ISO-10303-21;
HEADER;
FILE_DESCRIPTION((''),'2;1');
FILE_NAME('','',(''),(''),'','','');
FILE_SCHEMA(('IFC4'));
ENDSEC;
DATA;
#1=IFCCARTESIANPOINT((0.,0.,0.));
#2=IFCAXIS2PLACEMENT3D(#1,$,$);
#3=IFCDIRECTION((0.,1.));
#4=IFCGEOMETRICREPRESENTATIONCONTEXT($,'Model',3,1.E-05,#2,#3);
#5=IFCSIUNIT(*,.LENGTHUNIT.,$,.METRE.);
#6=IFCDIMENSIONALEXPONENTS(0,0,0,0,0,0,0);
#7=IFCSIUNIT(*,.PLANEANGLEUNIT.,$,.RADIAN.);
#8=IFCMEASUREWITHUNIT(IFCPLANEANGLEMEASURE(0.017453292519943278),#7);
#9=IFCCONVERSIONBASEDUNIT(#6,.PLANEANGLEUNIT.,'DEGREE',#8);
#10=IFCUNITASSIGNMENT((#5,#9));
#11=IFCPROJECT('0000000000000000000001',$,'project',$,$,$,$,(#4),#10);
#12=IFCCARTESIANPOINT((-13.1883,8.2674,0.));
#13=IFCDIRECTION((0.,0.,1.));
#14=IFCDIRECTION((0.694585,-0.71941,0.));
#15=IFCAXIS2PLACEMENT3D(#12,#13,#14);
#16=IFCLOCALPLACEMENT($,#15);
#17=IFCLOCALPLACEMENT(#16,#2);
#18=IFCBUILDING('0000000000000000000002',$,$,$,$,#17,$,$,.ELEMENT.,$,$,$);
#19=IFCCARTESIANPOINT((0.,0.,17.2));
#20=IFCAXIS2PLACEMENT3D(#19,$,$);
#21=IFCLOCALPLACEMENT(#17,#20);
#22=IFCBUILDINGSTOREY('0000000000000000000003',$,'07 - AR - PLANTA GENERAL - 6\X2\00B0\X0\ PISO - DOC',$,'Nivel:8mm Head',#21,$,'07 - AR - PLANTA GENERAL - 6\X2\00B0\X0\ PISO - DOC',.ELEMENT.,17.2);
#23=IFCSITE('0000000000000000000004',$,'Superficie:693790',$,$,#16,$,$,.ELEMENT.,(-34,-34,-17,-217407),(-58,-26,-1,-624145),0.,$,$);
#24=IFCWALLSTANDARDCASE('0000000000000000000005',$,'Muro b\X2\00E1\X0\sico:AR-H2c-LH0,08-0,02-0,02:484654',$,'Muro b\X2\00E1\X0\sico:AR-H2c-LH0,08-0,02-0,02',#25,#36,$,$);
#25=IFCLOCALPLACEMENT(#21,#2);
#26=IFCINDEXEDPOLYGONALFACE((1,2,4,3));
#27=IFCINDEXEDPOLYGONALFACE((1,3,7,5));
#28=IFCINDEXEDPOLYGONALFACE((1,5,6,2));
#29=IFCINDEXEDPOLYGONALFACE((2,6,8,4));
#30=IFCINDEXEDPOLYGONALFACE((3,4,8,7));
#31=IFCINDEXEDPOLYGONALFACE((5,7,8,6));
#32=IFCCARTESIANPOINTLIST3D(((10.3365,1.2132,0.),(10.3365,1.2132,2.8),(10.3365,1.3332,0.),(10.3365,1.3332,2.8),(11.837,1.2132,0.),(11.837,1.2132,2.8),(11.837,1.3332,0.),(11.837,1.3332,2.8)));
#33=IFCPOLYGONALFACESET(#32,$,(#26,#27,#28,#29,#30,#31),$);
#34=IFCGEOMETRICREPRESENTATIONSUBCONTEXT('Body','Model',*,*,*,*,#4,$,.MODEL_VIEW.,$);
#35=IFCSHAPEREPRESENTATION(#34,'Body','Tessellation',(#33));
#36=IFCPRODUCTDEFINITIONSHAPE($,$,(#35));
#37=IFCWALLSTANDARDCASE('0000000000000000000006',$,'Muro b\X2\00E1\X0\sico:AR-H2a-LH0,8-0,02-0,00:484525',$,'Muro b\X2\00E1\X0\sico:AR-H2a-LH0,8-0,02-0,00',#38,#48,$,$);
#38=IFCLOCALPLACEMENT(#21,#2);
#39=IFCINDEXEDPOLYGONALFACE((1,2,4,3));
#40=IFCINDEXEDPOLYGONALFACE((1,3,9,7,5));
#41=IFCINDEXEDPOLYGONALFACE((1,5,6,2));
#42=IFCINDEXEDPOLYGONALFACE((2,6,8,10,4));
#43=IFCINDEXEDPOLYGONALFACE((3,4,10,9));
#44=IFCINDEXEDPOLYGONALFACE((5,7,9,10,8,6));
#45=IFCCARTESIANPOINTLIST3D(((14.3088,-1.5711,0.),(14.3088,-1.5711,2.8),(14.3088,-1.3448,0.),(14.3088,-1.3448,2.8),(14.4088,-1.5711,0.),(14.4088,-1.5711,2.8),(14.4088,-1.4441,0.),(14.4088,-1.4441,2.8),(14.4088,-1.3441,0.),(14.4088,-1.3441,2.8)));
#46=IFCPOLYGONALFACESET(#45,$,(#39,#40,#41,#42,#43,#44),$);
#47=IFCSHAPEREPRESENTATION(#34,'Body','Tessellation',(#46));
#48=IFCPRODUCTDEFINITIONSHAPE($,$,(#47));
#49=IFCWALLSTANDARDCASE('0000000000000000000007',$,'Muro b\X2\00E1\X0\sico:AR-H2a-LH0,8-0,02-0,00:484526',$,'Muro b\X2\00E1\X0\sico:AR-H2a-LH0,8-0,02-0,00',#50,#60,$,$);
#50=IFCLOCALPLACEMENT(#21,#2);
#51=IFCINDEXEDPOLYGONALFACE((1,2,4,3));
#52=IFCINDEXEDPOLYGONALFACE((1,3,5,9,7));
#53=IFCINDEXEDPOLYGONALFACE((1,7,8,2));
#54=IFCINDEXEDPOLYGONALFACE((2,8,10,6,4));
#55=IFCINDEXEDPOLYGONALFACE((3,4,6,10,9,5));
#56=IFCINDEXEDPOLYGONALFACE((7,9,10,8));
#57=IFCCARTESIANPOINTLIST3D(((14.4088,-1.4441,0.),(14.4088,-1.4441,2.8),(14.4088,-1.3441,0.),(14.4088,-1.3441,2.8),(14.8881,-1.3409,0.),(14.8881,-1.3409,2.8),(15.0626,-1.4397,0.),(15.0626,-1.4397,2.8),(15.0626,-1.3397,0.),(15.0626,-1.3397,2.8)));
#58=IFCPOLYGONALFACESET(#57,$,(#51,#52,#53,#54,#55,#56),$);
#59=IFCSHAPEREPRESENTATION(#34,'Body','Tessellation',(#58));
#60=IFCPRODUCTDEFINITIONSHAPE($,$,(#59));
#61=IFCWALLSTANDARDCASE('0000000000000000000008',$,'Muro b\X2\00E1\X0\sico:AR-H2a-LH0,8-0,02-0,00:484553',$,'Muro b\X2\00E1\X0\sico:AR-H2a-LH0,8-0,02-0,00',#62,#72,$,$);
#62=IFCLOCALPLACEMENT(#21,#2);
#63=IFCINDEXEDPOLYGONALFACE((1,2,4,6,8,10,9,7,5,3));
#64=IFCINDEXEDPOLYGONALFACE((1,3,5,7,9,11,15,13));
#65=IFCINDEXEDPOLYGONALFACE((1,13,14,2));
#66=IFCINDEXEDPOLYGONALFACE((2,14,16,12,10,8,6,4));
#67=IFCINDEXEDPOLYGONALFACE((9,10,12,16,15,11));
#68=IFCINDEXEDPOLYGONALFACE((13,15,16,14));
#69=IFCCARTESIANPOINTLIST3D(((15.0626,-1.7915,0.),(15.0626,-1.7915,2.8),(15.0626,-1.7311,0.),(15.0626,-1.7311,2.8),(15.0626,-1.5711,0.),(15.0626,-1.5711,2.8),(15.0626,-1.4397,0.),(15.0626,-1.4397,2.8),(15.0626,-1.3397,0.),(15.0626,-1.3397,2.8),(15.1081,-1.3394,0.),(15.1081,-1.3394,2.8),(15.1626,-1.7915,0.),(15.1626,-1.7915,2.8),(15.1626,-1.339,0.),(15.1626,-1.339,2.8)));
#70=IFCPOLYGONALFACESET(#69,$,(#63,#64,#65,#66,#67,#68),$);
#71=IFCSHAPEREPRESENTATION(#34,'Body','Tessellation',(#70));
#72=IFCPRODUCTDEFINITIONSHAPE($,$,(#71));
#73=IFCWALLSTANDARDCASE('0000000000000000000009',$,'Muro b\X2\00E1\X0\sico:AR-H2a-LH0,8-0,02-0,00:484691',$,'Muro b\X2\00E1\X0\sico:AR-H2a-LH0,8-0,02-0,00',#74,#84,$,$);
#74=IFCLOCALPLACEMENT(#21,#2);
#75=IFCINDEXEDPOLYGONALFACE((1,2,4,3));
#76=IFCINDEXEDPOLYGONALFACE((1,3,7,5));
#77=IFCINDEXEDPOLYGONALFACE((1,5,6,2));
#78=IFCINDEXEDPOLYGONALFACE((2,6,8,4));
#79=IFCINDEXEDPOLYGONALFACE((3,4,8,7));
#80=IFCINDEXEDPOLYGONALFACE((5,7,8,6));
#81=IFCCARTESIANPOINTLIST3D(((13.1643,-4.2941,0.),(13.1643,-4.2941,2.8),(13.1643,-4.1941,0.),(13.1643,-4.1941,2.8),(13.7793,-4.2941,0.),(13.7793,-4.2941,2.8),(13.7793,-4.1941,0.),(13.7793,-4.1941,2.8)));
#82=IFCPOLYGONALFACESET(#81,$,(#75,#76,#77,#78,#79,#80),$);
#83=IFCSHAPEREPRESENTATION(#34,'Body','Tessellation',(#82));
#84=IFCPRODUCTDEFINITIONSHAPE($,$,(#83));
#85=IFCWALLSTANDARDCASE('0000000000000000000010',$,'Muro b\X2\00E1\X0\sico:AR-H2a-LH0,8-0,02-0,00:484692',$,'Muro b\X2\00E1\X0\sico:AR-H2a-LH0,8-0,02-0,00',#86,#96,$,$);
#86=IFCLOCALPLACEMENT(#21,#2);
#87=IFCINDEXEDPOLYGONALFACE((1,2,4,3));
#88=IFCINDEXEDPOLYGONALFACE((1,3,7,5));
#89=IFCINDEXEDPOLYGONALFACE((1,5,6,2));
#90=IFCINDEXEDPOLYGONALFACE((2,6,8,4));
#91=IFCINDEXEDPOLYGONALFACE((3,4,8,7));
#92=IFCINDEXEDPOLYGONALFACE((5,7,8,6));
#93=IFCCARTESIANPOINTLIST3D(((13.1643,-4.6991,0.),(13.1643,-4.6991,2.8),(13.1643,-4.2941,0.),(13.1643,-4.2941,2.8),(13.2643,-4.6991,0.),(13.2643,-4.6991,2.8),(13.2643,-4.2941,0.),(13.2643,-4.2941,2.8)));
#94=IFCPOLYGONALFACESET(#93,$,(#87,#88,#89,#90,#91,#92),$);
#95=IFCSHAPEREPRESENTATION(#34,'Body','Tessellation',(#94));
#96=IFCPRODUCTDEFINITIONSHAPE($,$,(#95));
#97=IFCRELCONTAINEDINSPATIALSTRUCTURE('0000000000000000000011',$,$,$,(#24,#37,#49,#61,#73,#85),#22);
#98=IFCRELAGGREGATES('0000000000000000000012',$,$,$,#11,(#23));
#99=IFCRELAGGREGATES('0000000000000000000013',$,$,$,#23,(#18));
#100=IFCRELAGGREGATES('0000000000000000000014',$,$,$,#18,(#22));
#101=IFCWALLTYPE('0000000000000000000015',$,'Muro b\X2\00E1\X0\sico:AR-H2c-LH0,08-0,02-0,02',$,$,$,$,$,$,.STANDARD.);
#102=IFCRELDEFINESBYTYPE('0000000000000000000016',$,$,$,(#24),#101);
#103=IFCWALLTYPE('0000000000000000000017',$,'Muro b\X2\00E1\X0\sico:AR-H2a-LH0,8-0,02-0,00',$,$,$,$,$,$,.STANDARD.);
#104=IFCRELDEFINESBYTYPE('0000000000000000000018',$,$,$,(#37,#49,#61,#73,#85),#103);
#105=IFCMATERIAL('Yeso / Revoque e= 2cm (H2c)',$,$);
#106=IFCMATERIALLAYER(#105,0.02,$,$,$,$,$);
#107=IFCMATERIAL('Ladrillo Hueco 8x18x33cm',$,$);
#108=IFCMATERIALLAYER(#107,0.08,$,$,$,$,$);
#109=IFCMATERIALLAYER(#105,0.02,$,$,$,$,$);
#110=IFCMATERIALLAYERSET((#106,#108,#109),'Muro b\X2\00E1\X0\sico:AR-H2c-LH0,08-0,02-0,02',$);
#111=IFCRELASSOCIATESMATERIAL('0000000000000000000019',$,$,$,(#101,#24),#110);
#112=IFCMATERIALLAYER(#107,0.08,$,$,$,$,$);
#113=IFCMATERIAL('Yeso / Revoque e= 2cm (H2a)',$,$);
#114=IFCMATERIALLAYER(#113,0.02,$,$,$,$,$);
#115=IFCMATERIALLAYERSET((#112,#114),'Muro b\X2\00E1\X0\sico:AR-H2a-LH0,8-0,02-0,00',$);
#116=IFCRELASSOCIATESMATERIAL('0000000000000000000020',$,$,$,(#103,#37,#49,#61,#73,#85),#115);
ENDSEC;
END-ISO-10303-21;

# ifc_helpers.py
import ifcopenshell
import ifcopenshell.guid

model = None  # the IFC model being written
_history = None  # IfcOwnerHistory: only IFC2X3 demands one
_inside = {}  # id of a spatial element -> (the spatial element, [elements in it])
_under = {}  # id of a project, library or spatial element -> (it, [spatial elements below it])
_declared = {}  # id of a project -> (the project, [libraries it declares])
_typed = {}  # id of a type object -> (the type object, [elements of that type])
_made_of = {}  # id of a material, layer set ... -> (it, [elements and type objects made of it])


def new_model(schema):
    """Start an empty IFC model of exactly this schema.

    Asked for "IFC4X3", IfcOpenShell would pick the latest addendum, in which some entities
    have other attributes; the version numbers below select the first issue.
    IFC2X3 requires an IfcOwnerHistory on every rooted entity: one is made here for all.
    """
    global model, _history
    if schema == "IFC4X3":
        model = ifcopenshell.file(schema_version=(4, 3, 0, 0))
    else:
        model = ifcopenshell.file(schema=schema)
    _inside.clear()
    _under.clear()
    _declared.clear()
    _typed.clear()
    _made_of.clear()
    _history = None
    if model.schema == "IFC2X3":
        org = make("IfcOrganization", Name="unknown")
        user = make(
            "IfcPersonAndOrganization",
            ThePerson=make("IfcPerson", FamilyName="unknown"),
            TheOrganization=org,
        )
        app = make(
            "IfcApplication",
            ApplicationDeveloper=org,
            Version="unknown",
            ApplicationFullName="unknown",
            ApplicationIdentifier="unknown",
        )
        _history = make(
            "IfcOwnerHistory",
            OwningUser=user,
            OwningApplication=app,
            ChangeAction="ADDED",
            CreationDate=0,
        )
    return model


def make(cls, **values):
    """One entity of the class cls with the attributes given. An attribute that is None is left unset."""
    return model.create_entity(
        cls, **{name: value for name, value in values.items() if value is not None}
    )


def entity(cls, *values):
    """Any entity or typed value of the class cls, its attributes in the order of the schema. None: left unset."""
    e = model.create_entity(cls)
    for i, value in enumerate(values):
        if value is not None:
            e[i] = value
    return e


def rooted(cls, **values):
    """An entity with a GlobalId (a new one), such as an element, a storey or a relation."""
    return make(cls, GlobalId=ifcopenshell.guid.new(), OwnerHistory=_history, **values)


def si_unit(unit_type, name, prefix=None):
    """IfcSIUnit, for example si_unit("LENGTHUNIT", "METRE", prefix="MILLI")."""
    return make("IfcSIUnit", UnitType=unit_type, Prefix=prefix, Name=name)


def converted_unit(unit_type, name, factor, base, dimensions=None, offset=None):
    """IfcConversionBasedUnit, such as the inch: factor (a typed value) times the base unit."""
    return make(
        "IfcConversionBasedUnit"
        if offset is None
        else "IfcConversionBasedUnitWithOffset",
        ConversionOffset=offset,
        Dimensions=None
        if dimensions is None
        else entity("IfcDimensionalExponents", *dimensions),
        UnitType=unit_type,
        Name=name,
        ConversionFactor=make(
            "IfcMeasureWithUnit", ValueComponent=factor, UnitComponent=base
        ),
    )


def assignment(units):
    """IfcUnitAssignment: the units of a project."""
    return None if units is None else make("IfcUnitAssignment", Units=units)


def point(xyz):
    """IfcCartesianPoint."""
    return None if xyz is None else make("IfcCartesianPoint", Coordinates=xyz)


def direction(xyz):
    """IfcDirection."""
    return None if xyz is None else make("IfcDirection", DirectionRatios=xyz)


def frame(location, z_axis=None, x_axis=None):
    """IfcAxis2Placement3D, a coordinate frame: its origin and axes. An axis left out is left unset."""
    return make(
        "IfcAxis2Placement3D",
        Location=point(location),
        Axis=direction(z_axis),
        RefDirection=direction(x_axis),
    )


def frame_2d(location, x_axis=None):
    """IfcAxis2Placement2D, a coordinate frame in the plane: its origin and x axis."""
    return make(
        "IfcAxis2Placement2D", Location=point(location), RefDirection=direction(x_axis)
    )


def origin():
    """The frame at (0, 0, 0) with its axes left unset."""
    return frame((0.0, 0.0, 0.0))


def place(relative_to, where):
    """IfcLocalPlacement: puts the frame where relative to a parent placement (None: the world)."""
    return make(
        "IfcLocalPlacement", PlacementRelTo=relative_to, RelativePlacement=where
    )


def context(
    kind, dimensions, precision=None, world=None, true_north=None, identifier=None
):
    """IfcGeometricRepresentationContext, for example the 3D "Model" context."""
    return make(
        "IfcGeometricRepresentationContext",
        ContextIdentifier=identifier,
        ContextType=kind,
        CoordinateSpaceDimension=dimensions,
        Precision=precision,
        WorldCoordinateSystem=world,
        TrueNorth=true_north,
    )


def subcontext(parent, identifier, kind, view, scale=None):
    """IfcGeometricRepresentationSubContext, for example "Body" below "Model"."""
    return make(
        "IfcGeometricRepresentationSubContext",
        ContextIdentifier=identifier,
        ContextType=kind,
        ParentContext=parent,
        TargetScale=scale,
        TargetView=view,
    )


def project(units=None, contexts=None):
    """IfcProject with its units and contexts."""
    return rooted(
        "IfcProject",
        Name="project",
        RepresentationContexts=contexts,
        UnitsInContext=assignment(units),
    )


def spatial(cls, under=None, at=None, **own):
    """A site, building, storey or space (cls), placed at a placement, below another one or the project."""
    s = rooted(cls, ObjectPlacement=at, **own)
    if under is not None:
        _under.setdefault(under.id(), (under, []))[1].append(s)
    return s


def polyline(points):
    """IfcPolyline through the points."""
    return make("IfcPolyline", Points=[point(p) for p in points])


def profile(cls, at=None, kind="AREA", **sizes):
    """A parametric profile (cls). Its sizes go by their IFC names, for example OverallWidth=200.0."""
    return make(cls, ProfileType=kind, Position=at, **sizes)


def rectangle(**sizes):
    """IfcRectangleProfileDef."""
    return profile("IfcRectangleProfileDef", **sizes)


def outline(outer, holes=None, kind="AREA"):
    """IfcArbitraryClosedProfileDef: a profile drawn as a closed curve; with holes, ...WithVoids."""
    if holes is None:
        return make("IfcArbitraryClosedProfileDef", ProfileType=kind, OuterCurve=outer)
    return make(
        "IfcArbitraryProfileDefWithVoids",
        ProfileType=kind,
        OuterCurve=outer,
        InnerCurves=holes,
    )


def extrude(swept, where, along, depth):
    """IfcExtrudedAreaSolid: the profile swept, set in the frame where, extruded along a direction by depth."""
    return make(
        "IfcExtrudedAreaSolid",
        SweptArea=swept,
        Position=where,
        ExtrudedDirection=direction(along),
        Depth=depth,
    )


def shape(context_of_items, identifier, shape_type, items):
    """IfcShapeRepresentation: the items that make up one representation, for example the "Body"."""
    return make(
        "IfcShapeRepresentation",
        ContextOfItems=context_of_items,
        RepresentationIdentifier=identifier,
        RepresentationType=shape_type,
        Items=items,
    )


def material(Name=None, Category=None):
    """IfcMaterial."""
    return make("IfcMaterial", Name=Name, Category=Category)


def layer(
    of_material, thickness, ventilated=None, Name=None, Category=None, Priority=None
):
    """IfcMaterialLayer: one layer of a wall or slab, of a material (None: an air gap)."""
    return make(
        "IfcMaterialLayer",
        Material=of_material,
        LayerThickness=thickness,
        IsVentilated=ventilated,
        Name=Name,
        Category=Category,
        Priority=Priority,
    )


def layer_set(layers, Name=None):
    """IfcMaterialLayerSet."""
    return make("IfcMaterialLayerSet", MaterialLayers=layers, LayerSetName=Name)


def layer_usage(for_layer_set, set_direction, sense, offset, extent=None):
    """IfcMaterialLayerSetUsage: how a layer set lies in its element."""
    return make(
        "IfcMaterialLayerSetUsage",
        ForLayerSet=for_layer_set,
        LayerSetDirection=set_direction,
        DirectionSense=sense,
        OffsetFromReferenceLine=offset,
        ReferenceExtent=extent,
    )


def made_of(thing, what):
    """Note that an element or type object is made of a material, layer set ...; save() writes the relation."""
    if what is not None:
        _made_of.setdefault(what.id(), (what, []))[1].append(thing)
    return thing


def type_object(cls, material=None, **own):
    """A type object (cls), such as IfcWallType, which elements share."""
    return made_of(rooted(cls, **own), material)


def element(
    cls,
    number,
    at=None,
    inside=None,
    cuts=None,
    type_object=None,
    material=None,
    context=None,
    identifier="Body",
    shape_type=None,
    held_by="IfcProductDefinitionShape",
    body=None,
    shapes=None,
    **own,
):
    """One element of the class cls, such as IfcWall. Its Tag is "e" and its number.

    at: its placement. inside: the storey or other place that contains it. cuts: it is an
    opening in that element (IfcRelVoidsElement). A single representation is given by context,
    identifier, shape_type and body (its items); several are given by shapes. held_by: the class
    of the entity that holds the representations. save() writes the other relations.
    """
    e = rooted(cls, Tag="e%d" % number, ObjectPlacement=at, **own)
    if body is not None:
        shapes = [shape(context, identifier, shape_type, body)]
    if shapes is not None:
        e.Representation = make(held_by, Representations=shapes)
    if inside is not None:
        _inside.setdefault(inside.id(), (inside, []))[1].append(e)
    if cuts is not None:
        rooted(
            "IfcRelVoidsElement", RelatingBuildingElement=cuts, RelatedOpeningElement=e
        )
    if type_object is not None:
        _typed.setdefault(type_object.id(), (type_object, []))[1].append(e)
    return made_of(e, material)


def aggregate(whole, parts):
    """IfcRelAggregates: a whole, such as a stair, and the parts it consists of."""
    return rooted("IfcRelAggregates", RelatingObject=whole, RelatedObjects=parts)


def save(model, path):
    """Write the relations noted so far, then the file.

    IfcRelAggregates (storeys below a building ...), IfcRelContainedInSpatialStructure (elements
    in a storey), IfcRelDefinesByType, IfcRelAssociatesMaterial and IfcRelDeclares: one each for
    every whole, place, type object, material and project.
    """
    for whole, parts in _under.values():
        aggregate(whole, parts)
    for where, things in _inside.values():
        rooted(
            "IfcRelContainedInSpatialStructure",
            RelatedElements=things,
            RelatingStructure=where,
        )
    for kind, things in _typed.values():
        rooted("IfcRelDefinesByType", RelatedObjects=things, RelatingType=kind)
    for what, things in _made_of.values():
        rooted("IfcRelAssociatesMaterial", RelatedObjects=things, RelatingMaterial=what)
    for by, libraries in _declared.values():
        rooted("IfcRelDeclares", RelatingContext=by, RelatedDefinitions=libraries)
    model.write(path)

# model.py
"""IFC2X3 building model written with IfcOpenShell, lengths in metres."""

from ifc_helpers import new_model, entity, si_unit, converted_unit, direction, frame, frame_2d, origin, place, context, subcontext, project, spatial, polyline, rectangle, outline, extrude, material, layer, layer_set, layer_usage, type_object, element, save


model = new_model("IFC2X3")

# Units and contexts
model_context = context("Model", 3, precision=1e-05, world=origin(), true_north=direction((0.0, 1.0)))
body_context = subcontext(model_context, "Body", "Model", "MODEL_VIEW")
ifc_project = project(units=[si_unit("LENGTHUNIT", "METRE"), converted_unit("PLANEANGLEUNIT", "DEGREE", entity("IfcPlaneAngleMeasure", 0.017453292519943278), si_unit("PLANEANGLEUNIT", "RADIAN"), dimensions=[0, 0, 0, 0, 0, 0, 0])], contexts=[model_context])

# Site, building, storey
site_placement = place(None, frame((-13.1883, 8.2674, 0.0), z_axis=(0.0, 0.0, 1.0), x_axis=(0.694585, -0.71941, 0.0)))
site = spatial("IfcSite", under=ifc_project, at=site_placement, Name="Superficie:693790", CompositionType="ELEMENT", RefLatitude=(-34, -34, -17, -217407), RefLongitude=(-58, -26, -1, -624145), RefElevation=0.0)
building_placement = place(site_placement, origin())
building = spatial("IfcBuilding", under=site, at=building_placement, CompositionType="ELEMENT")
storey_placement = place(building_placement, frame((0.0, 0.0, 17.2)))
storey = spatial("IfcBuildingStorey", under=building, at=storey_placement, Name="07 - AR - PLANTA GENERAL - 6° PISO - DOC", ObjectType="Nivel:8mm Head", LongName="07 - AR - PLANTA GENERAL - 6° PISO - DOC", CompositionType="ELEMENT", Elevation=17.2)

# Walls
ifc_material_1 = material(Name="Yeso / Revoque e= 2cm (H2c)")
ifc_layer_1 = layer(ifc_material_1, 0.02)
ifc_material_2 = material(Name="Ladrillo Hueco 8x18x33cm")
ifc_layer_2 = layer(ifc_material_2, 0.08)
ifc_layer_3 = layer(ifc_material_1, 0.02)
ifc_layer_set_1 = layer_set([ifc_layer_1, ifc_layer_2, ifc_layer_3], Name="Muro básico:AR-H2c-LH0,08-0,02-0,02")
ifc_layer_usage_1 = layer_usage(ifc_layer_set_1, "AXIS2", "NEGATIVE", 0.06)
wall_type_1 = type_object("IfcWallType", Name="Muro básico:AR-H2c-LH0,08-0,02-0,02", PredefinedType="STANDARD", material=ifc_layer_set_1)
wall_1_placement = place(storey_placement, frame((11.837, 1.2732, 0.0), z_axis=(0.0, 0.0, 1.0), x_axis=(-1.0, 0.0, 0.0)))
element("IfcWallStandardCase", 1, at=wall_1_placement, inside=storey, type_object=wall_type_1, material=ifc_layer_usage_1, Name="Muro básico:AR-H2c-LH0,08-0,02-0,02:484654", ObjectType="Muro básico:AR-H2c-LH0,08-0,02-0,02", context=body_context, shape_type="SweptSolid", body=[
    extrude(rectangle(XDim=1.5005, YDim=0.12, at=frame_2d((0.7503, 0.0), x_axis=(-1.0, 0.0))), origin(), (0.0, 0.0, 1.0), 2.8),
])
ifc_layer_4 = layer(ifc_material_2, 0.08)
ifc_material_3 = material(Name="Yeso / Revoque e= 2cm (H2a)")
ifc_layer_5 = layer(ifc_material_3, 0.02)
ifc_layer_set_2 = layer_set([ifc_layer_4, ifc_layer_5], Name="Muro básico:AR-H2a-LH0,8-0,02-0,00")
ifc_layer_usage_2 = layer_usage(ifc_layer_set_2, "AXIS2", "POSITIVE", -0.05)
wall_type_2 = type_object("IfcWallType", Name="Muro básico:AR-H2a-LH0,8-0,02-0,00", PredefinedType="STANDARD", material=ifc_layer_set_2)
wall_2_placement = place(storey_placement, frame((14.3588, -1.5711, 0.0), z_axis=(0.0, 0.0, 1.0), x_axis=(0.0, 1.0, 0.0)))
element("IfcWallStandardCase", 2, at=wall_2_placement, inside=storey, type_object=wall_type_2, material=ifc_layer_usage_2, Name="Muro básico:AR-H2a-LH0,8-0,02-0,00:484525", ObjectType="Muro básico:AR-H2a-LH0,8-0,02-0,00", context=body_context, shape_type="SweptSolid", body=[
    extrude(outline(polyline([(0.2269, -0.05), (0.2262, 0.05), (0.0, 0.05), (0.0, -0.05), (0.1269, -0.05), (0.2269, -0.05)])), origin(), (0.0, 0.0, 1.0), 2.8),
])
ifc_layer_usage_3 = layer_usage(ifc_layer_set_2, "AXIS2", "POSITIVE", -0.05)
wall_3_placement = place(storey_placement, frame((14.4085, -1.3941, 0.0), z_axis=(0.0, 0.0, 1.0), x_axis=(0.999977, 0.006798, 0.0)))
element("IfcWallStandardCase", 3, at=wall_3_placement, inside=storey, type_object=wall_type_2, material=ifc_layer_usage_3, Name="Muro básico:AR-H2a-LH0,8-0,02-0,00:484526", ObjectType="Muro básico:AR-H2a-LH0,8-0,02-0,00", context=body_context, shape_type="SweptSolid", body=[
    extrude(outline(polyline([(0.6538, -0.05), (0.6544, 0.05), (0.4799, 0.05), (0.0007, 0.05), (0.0, -0.05), (0.6538, -0.05)])), origin(), (0.0, 0.0, 1.0), 2.8),
])
ifc_layer_usage_4 = layer_usage(ifc_layer_set_2, "AXIS2", "NEGATIVE", 0.05)
wall_4_placement = place(storey_placement, frame((15.1126, -1.7915, 0.0), z_axis=(0.0, 0.0, 1.0), x_axis=(0.0, 1.0, 0.0)))
element("IfcWallStandardCase", 4, at=wall_4_placement, inside=storey, type_object=wall_type_2, material=ifc_layer_usage_4, Name="Muro básico:AR-H2a-LH0,8-0,02-0,00:484553", ObjectType="Muro básico:AR-H2a-LH0,8-0,02-0,00", context=body_context, shape_type="SweptSolid", body=[
    extrude(outline(polyline([(0.4525, -0.05), (0.4521, 0.0045), (0.4518, 0.05), (0.3518, 0.05), (0.2204, 0.05), (0.0604, 0.05), (0.0, 0.05), (0.0, -0.05), (0.4525, -0.05)])), origin(), (0.0, 0.0, 1.0), 2.8),
])
ifc_layer_usage_5 = layer_usage(ifc_layer_set_2, "AXIS2", "NEGATIVE", 0.05)
wall_5_placement = place(storey_placement, frame((13.7793, -4.2441, 0.0), z_axis=(0.0, 0.0, 1.0), x_axis=(-1.0, 0.0, 0.0)))
element("IfcWallStandardCase", 5, at=wall_5_placement, inside=storey, type_object=wall_type_2, material=ifc_layer_usage_5, Name="Muro básico:AR-H2a-LH0,8-0,02-0,00:484691", ObjectType="Muro básico:AR-H2a-LH0,8-0,02-0,00", context=body_context, shape_type="SweptSolid", body=[
    extrude(rectangle(XDim=0.615, YDim=0.1, at=frame_2d((0.3075, 0.0), x_axis=(-1.0, 0.0))), origin(), (0.0, 0.0, 1.0), 2.8),
])
ifc_layer_usage_6 = layer_usage(ifc_layer_set_2, "AXIS2", "NEGATIVE", 0.05)
wall_6_placement = place(storey_placement, frame((13.2143, -4.2941, 0.0), z_axis=(0.0, 0.0, 1.0), x_axis=(0.0, -1.0, 0.0)))
element("IfcWallStandardCase", 6, at=wall_6_placement, inside=storey, type_object=wall_type_2, material=ifc_layer_usage_6, Name="Muro básico:AR-H2a-LH0,8-0,02-0,00:484692", ObjectType="Muro básico:AR-H2a-LH0,8-0,02-0,00", context=body_context, shape_type="SweptSolid", body=[
    extrude(rectangle(XDim=0.405, YDim=0.1, at=frame_2d((0.2025, 0.0), x_axis=(-1.0, 0.0))), origin(), (0.0, 0.0, 1.0), 2.8),
])

save(model, "model.ifc")
